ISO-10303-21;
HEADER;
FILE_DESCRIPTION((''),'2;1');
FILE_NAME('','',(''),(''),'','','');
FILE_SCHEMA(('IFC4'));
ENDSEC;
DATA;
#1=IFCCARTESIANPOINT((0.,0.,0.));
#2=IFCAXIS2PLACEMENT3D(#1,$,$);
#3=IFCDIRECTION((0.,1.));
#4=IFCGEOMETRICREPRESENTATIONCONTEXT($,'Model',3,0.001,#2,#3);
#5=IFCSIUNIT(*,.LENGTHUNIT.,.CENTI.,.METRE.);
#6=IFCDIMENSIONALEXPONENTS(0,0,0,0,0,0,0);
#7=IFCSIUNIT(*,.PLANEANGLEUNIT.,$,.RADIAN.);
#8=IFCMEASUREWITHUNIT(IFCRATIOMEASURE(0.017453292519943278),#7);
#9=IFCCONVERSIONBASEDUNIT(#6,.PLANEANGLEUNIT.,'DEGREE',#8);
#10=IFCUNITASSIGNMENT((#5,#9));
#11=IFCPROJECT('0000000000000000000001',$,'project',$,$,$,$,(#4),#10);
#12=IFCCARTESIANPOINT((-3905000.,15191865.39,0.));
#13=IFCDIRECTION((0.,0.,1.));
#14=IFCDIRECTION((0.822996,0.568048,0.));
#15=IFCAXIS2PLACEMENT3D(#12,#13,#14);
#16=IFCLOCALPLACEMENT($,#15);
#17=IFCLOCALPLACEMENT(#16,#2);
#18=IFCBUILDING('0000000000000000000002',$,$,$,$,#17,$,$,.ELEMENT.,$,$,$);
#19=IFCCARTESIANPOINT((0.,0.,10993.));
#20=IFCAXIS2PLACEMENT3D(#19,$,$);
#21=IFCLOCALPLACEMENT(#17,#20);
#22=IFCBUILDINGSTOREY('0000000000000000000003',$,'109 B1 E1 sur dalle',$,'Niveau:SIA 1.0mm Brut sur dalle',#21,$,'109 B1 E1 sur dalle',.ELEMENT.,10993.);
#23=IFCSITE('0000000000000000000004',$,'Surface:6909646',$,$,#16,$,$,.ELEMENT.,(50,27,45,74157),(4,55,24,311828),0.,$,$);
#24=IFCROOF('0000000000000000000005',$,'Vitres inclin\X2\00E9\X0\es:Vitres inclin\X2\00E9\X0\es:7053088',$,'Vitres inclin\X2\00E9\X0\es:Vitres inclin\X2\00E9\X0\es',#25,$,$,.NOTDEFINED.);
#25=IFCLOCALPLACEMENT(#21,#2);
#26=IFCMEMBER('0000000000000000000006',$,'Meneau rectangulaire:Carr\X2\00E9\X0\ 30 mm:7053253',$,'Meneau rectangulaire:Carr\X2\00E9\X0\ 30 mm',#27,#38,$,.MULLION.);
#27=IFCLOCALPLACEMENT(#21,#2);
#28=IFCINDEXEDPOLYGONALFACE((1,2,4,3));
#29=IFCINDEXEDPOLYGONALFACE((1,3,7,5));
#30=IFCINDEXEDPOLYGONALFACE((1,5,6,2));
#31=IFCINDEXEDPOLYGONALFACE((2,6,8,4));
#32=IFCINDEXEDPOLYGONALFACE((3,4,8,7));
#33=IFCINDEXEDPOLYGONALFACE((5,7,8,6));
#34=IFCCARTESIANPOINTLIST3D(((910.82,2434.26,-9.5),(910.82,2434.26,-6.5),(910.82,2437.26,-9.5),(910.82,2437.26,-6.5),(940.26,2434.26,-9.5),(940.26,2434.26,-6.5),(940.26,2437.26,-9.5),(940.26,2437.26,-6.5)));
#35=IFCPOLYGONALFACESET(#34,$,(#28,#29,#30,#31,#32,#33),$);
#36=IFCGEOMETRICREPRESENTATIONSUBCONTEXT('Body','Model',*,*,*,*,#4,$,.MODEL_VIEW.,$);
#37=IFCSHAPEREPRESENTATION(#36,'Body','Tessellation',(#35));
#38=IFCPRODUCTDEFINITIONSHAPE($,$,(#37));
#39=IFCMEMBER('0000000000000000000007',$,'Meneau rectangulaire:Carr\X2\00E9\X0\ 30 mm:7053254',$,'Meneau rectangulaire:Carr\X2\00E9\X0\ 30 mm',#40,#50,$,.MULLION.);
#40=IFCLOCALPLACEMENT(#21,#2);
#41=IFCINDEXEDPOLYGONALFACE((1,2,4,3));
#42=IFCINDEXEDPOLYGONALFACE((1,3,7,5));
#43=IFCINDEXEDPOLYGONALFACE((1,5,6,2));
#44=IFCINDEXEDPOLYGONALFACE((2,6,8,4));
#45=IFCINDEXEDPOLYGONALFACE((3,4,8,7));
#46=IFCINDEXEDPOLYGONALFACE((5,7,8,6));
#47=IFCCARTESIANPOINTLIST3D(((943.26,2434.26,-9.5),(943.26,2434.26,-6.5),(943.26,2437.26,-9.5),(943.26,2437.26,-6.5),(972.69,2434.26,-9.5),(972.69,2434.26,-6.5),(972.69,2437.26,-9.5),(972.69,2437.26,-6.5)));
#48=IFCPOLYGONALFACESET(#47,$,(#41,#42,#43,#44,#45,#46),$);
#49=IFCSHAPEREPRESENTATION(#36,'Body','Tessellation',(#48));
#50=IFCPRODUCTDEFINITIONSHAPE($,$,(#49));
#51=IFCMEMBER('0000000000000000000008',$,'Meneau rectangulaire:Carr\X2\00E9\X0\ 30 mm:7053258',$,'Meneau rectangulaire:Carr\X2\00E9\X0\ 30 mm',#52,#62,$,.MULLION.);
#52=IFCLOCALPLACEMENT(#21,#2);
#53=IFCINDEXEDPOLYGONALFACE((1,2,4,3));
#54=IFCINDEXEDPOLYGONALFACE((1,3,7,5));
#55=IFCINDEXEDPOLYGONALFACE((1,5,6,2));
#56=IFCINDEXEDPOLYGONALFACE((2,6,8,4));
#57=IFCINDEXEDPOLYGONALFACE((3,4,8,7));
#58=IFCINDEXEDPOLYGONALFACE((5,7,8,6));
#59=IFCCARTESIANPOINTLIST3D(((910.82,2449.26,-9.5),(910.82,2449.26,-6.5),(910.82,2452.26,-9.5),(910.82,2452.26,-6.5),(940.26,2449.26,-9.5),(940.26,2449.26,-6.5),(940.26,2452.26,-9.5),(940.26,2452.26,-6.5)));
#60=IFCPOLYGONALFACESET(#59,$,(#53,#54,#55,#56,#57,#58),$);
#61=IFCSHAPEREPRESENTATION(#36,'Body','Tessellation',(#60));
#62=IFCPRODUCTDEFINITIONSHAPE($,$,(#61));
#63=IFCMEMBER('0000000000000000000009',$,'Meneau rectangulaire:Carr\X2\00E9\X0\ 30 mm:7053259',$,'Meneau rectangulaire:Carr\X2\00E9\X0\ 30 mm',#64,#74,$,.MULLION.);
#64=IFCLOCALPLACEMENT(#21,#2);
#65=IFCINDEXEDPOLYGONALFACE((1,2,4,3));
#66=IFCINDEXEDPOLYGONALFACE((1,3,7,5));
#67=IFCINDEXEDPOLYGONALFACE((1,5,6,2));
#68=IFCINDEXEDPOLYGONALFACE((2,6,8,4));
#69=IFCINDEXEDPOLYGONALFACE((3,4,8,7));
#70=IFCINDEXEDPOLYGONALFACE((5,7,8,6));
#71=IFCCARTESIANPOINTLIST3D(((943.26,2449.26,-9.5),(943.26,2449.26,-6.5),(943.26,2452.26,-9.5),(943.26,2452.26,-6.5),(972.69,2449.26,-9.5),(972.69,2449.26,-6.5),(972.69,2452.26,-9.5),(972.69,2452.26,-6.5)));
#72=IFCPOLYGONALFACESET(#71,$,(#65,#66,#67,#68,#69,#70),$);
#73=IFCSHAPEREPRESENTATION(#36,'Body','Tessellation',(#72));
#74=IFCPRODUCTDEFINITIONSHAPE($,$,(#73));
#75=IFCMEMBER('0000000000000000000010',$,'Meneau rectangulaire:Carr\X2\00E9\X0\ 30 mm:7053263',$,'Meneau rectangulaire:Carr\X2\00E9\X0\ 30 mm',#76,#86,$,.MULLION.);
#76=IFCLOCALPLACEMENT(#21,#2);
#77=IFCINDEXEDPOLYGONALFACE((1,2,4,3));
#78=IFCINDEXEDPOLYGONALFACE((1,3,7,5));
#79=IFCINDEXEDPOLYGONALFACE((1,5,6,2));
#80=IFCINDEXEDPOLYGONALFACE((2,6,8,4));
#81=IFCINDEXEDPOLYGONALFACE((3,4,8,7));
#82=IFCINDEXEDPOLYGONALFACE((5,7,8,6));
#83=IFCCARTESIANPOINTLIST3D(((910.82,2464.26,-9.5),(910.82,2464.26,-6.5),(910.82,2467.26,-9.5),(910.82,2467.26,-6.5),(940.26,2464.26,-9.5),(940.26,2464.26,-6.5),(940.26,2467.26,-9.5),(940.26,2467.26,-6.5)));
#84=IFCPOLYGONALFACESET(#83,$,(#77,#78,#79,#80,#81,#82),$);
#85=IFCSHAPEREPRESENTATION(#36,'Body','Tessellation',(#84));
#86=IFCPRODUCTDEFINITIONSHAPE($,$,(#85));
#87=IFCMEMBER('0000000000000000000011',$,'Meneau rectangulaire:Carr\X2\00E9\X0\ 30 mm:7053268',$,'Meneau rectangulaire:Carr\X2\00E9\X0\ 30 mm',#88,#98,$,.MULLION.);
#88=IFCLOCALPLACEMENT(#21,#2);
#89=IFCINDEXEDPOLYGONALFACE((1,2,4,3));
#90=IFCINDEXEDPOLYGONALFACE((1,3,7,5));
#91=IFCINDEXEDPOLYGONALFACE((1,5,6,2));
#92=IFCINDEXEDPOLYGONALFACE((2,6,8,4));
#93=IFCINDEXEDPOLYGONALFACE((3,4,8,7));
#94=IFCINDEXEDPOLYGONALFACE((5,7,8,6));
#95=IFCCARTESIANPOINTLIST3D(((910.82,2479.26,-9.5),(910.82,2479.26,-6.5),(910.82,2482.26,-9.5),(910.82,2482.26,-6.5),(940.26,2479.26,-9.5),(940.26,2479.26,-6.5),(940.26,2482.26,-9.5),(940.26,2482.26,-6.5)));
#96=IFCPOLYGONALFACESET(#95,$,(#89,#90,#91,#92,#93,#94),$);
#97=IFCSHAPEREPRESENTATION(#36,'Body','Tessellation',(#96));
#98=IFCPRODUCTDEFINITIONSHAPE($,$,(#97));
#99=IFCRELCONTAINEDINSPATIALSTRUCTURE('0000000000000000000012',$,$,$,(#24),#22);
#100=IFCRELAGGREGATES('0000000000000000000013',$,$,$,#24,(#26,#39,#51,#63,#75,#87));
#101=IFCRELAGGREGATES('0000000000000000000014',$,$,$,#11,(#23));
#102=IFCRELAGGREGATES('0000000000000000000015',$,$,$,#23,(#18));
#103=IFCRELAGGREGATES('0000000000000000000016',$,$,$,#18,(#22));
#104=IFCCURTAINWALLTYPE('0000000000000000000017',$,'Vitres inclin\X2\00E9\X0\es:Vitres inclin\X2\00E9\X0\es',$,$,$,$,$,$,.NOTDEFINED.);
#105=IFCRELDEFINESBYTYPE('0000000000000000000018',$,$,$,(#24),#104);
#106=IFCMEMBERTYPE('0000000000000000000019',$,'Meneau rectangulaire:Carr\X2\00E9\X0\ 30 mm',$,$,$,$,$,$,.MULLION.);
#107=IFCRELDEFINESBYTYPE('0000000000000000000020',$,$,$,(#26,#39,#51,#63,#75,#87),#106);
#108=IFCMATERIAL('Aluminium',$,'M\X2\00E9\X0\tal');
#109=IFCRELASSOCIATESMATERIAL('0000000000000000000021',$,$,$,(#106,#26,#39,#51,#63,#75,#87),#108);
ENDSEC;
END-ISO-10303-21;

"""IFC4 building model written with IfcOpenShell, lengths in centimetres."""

from ifc_helpers import new_model, entity, si_unit, converted_unit, direction, frame, origin, place, context, subcontext, project, spatial, indexed_curve, outline, extrude, source, transform, mapped, material, type_object, type_shapes, element, aggregate, save


model = new_model("IFC4")

# Units and contexts
model_context = context("Model", 3, precision=0.001, world=origin(), true_north=direction((0.0, 1.0)))
body_context = subcontext(model_context, "Body", "Model", "MODEL_VIEW")
ifc_project = project(units=[si_unit("LENGTHUNIT", "METRE", prefix="CENTI"), converted_unit("PLANEANGLEUNIT", "DEGREE", entity("IfcRatioMeasure", 0.017453292519943278), si_unit("PLANEANGLEUNIT", "RADIAN"), dimensions=[0, 0, 0, 0, 0, 0, 0])], contexts=[model_context])

# Site, building, storey
site_placement = place(None, frame((-3905000.0, 15191865.39, 0.0), z_axis=(0.0, 0.0, 1.0), x_axis=(0.822996, 0.568048, 0.0)))
site = spatial("IfcSite", under=ifc_project, at=site_placement, Name="Surface:6909646", CompositionType="ELEMENT", RefLatitude=(50, 27, 45, 74157), RefLongitude=(4, 55, 24, 311828), RefElevation=0.0)
building_placement = place(site_placement, origin())
building = spatial("IfcBuilding", under=site, at=building_placement, CompositionType="ELEMENT")
storey_placement = place(building_placement, frame((0.0, 0.0, 10993.0)))
storey = spatial("IfcBuildingStorey", under=building, at=storey_placement, Name="109 B1 E1 sur dalle", ObjectType="Niveau:SIA 1.0mm Brut sur dalle", LongName="109 B1 E1 sur dalle", CompositionType="ELEMENT", Elevation=10993.0)

# Roof, members
curtain_wall_type = type_object("IfcCurtainWallType", Name="Vitres inclinées:Vitres inclinées", PredefinedType="NOTDEFINED")
roof_placement = place(storey_placement, frame((0.0, 0.0, -10993.0)))
roof = element("IfcRoof", 1, at=roof_placement, inside=storey, type_object=curtain_wall_type, Name="Vitres inclinées:Vitres inclinées:7053088", ObjectType="Vitres inclinées:Vitres inclinées", PredefinedType="NOTDEFINED")
ifc_material = material(Name="Aluminium", Category="Métal")
member_type_1 = type_object("IfcMemberType", Name="Meneau rectangulaire:Carré 30 mm", PredefinedType="MULLION", material=ifc_material)
shared_shape_1 = source(origin(), body_context, "Body", "SweptSolid", [
    extrude(outline(indexed_curve([(-1.5, -1.5), (1.5, -1.5), (1.5, 1.5), (-1.5, 1.5), (-1.5, -1.5)], self_intersect=False)), frame((0.0, 0.0, -29.44), z_axis=(0.0, 0.0, 1.0), x_axis=(0.0, -1.0, 0.0)), (0.0, 0.0, 1.0), 29.44),
])
type_shapes(member_type_1, [shared_shape_1])
member_1_placement = place(roof_placement, frame((910.82, 2435.76, 10985.0), z_axis=(-1.0, 0.0, 0.0), x_axis=(0.0, 1.0, 0.0)))
member_1 = element("IfcMember", 2, at=member_1_placement, type_object=member_type_1, material=ifc_material, Name="Meneau rectangulaire:Carré 30 mm:7053253", ObjectType="Meneau rectangulaire:Carré 30 mm", PredefinedType="MULLION", context=body_context, shape_type="MappedRepresentation", body=[
    mapped(shared_shape_1, transform((0.0, 0.0, 0.0), scale=1.0)),
])
member_2_placement = place(roof_placement, frame((943.26, 2435.76, 10985.0), z_axis=(-1.0, 0.0, 0.0), x_axis=(0.0, 1.0, 0.0)))
member_2 = element("IfcMember", 3, at=member_2_placement, type_object=member_type_1, material=ifc_material, Name="Meneau rectangulaire:Carré 30 mm:7053254", ObjectType="Meneau rectangulaire:Carré 30 mm", PredefinedType="MULLION", context=body_context, shape_type="MappedRepresentation", body=[
    mapped(shared_shape_1, transform((0.0, 0.0, 0.0), scale=1.0)),
])
member_3_placement = place(roof_placement, frame((910.82, 2450.76, 10985.0), z_axis=(-1.0, 0.0, 0.0), x_axis=(0.0, 1.0, 0.0)))
member_3 = element("IfcMember", 4, at=member_3_placement, type_object=member_type_1, material=ifc_material, Name="Meneau rectangulaire:Carré 30 mm:7053258", ObjectType="Meneau rectangulaire:Carré 30 mm", PredefinedType="MULLION", context=body_context, shape_type="MappedRepresentation", body=[
    mapped(shared_shape_1, transform((0.0, 0.0, 0.0), scale=1.0)),
])
member_4_placement = place(roof_placement, frame((943.26, 2450.76, 10985.0), z_axis=(-1.0, 0.0, 0.0), x_axis=(0.0, 1.0, 0.0)))
member_4 = element("IfcMember", 5, at=member_4_placement, type_object=member_type_1, material=ifc_material, Name="Meneau rectangulaire:Carré 30 mm:7053259", ObjectType="Meneau rectangulaire:Carré 30 mm", PredefinedType="MULLION", context=body_context, shape_type="MappedRepresentation", body=[
    mapped(shared_shape_1, transform((0.0, 0.0, 0.0), scale=1.0)),
])
member_5_placement = place(roof_placement, frame((910.82, 2465.76, 10985.0), z_axis=(-1.0, 0.0, 0.0), x_axis=(0.0, 1.0, 0.0)))
member_5 = element("IfcMember", 6, at=member_5_placement, type_object=member_type_1, material=ifc_material, Name="Meneau rectangulaire:Carré 30 mm:7053263", ObjectType="Meneau rectangulaire:Carré 30 mm", PredefinedType="MULLION", context=body_context, shape_type="MappedRepresentation", body=[
    mapped(shared_shape_1, transform((0.0, 0.0, 0.0), scale=1.0)),
])
member_6_placement = place(roof_placement, frame((910.82, 2480.76, 10985.0), z_axis=(-1.0, 0.0, 0.0), x_axis=(0.0, 1.0, 0.0)))
member_6 = element("IfcMember", 7, at=member_6_placement, type_object=member_type_1, material=ifc_material, Name="Meneau rectangulaire:Carré 30 mm:7053268", ObjectType="Meneau rectangulaire:Carré 30 mm", PredefinedType="MULLION", context=body_context, shape_type="MappedRepresentation", body=[
    mapped(shared_shape_1, transform((0.0, 0.0, 0.0), scale=1.0)),
])
aggregate(roof, [member_1, member_2, member_3, member_4, member_5, member_6])

save(model, "model.ifc")
